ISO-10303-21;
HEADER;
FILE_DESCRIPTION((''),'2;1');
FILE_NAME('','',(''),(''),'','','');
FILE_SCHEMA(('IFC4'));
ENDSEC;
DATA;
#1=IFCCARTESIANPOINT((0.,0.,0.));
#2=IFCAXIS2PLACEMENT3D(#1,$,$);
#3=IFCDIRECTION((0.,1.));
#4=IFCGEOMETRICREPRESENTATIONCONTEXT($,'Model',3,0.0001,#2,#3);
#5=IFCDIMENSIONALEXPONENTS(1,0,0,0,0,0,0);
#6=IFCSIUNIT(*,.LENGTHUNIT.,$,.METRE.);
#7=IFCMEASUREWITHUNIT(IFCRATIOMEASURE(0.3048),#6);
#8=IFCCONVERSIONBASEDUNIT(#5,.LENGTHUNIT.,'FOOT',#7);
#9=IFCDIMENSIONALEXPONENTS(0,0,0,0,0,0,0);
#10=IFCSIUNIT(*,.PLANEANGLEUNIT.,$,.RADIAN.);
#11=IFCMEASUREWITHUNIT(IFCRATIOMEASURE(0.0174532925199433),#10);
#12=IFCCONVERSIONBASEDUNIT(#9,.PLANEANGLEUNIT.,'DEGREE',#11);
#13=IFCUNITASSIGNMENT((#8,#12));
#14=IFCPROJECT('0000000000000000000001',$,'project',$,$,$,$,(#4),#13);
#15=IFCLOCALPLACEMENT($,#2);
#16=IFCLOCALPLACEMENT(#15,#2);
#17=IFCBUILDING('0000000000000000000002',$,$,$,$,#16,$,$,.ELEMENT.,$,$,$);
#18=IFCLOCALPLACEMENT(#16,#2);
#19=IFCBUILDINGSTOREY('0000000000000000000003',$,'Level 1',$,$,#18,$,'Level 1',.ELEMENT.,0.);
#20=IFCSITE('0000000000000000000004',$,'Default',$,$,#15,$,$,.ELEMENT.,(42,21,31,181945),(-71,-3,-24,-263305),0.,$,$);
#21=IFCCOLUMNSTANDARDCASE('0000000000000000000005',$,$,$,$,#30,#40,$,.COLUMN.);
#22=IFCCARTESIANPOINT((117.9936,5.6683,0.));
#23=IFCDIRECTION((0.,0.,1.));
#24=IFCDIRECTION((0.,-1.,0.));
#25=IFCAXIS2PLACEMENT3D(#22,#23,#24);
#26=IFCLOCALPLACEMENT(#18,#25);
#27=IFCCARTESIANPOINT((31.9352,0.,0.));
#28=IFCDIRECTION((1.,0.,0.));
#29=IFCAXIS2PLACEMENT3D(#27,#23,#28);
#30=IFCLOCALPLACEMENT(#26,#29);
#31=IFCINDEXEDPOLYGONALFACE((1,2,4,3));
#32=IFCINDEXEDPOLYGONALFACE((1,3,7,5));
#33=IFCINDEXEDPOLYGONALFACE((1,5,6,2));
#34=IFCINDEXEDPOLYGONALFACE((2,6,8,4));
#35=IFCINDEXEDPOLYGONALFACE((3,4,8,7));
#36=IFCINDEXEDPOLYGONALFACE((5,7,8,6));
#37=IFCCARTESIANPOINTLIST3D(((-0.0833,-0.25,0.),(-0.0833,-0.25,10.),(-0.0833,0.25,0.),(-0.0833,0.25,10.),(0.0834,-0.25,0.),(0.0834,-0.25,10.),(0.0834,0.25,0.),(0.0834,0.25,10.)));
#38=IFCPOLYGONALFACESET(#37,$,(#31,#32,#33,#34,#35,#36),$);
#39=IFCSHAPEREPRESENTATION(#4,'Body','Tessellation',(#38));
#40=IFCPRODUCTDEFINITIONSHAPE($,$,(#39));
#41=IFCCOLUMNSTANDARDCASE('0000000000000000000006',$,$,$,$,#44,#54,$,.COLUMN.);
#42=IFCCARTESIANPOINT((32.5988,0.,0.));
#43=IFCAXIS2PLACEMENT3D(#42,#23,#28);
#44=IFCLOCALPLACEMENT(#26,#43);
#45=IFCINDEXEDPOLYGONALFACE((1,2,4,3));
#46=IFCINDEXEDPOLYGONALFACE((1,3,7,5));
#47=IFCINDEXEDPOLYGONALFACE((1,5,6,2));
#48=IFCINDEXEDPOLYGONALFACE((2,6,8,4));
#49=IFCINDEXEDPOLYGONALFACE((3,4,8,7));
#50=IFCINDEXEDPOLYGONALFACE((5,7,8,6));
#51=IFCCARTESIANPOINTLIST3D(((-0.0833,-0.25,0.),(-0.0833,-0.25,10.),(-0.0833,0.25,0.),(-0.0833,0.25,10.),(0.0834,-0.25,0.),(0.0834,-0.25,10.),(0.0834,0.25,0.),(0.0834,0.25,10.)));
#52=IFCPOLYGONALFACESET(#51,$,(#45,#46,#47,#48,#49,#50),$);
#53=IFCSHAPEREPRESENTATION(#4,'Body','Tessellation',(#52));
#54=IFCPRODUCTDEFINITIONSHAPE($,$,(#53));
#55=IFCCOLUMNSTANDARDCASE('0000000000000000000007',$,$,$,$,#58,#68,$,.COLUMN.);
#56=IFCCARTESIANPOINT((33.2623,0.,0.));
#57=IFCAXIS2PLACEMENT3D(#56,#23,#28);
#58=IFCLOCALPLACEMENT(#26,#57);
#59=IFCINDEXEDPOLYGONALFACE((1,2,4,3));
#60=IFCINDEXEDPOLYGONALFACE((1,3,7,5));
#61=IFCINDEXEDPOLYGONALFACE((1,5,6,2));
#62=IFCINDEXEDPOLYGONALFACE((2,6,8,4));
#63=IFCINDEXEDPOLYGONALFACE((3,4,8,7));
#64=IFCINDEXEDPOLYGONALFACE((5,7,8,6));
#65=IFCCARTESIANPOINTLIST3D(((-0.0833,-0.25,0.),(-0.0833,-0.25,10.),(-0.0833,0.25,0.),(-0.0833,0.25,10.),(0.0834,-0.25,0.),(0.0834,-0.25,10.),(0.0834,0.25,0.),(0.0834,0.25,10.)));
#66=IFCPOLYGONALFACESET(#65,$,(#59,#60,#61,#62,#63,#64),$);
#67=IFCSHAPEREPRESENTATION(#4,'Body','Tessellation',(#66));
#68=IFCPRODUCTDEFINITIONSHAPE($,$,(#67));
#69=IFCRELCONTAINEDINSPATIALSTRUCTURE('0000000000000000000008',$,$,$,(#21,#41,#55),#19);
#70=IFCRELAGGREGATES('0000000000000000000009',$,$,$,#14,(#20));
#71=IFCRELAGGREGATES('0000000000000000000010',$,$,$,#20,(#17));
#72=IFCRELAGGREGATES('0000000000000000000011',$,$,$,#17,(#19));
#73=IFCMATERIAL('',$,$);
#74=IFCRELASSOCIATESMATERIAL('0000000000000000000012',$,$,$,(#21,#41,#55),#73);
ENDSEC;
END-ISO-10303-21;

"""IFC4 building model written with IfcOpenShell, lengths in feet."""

from ifc_helpers import new_model, entity, si_unit, converted_unit, direction, frame, origin, place, context, project, spatial, rectangle, extrude, material, element, save


model = new_model("IFC4")

# Units and contexts
model_context = context("Model", 3, precision=0.0001, world=origin(), true_north=direction((0.0, 1.0)))
ifc_project = project(units=[converted_unit("LENGTHUNIT", "FOOT", entity("IfcRatioMeasure", 0.3048), si_unit("LENGTHUNIT", "METRE"), dimensions=[1, 0, 0, 0, 0, 0, 0]), converted_unit("PLANEANGLEUNIT", "DEGREE", entity("IfcRatioMeasure", 0.0174532925199433), si_unit("PLANEANGLEUNIT", "RADIAN"), dimensions=[0, 0, 0, 0, 0, 0, 0])], contexts=[model_context])

# Site, building, storey
site_placement = place(None, origin())
site = spatial("IfcSite", under=ifc_project, at=site_placement, Name="Default", CompositionType="ELEMENT", RefLatitude=(42, 21, 31, 181945), RefLongitude=(-71, -3, -24, -263305), RefElevation=0.0)
building_placement = place(site_placement, origin())
building = spatial("IfcBuilding", under=site, at=building_placement, CompositionType="ELEMENT")
storey_placement = place(building_placement, origin())
storey = spatial("IfcBuildingStorey", under=building, at=storey_placement, Name="Level 1", LongName="Level 1", CompositionType="ELEMENT", Elevation=0.0)

# Columns
ifc_material = material(Name="")
placement = place(storey_placement, frame((117.9936, 5.6683, 0.0), z_axis=(0.0, 0.0, 1.0), x_axis=(0.0, -1.0, 0.0)))
for number, where, z_axis, x_axis in (
    (1, (31.9352, 0.0, 0.0), (0.0, 0.0, 1.0), (1.0, 0.0, 0.0)),
    (2, (32.5988, 0.0, 0.0), (0.0, 0.0, 1.0), (1.0, 0.0, 0.0)),
    (3, (33.2623, 0.0, 0.0), (0.0, 0.0, 1.0), (1.0, 0.0, 0.0)),
):
    element("IfcColumnStandardCase", number, at=place(placement, frame(where, z_axis=z_axis, x_axis=x_axis)), inside=storey, material=ifc_material, PredefinedType="COLUMN", context=model_context, shape_type="SweptSolid", body=[
        extrude(rectangle(XDim=0.1667, YDim=0.5), origin(), (0.0, 0.0, 1.0), 10.0),
    ])

save(model, "model.ifc")
